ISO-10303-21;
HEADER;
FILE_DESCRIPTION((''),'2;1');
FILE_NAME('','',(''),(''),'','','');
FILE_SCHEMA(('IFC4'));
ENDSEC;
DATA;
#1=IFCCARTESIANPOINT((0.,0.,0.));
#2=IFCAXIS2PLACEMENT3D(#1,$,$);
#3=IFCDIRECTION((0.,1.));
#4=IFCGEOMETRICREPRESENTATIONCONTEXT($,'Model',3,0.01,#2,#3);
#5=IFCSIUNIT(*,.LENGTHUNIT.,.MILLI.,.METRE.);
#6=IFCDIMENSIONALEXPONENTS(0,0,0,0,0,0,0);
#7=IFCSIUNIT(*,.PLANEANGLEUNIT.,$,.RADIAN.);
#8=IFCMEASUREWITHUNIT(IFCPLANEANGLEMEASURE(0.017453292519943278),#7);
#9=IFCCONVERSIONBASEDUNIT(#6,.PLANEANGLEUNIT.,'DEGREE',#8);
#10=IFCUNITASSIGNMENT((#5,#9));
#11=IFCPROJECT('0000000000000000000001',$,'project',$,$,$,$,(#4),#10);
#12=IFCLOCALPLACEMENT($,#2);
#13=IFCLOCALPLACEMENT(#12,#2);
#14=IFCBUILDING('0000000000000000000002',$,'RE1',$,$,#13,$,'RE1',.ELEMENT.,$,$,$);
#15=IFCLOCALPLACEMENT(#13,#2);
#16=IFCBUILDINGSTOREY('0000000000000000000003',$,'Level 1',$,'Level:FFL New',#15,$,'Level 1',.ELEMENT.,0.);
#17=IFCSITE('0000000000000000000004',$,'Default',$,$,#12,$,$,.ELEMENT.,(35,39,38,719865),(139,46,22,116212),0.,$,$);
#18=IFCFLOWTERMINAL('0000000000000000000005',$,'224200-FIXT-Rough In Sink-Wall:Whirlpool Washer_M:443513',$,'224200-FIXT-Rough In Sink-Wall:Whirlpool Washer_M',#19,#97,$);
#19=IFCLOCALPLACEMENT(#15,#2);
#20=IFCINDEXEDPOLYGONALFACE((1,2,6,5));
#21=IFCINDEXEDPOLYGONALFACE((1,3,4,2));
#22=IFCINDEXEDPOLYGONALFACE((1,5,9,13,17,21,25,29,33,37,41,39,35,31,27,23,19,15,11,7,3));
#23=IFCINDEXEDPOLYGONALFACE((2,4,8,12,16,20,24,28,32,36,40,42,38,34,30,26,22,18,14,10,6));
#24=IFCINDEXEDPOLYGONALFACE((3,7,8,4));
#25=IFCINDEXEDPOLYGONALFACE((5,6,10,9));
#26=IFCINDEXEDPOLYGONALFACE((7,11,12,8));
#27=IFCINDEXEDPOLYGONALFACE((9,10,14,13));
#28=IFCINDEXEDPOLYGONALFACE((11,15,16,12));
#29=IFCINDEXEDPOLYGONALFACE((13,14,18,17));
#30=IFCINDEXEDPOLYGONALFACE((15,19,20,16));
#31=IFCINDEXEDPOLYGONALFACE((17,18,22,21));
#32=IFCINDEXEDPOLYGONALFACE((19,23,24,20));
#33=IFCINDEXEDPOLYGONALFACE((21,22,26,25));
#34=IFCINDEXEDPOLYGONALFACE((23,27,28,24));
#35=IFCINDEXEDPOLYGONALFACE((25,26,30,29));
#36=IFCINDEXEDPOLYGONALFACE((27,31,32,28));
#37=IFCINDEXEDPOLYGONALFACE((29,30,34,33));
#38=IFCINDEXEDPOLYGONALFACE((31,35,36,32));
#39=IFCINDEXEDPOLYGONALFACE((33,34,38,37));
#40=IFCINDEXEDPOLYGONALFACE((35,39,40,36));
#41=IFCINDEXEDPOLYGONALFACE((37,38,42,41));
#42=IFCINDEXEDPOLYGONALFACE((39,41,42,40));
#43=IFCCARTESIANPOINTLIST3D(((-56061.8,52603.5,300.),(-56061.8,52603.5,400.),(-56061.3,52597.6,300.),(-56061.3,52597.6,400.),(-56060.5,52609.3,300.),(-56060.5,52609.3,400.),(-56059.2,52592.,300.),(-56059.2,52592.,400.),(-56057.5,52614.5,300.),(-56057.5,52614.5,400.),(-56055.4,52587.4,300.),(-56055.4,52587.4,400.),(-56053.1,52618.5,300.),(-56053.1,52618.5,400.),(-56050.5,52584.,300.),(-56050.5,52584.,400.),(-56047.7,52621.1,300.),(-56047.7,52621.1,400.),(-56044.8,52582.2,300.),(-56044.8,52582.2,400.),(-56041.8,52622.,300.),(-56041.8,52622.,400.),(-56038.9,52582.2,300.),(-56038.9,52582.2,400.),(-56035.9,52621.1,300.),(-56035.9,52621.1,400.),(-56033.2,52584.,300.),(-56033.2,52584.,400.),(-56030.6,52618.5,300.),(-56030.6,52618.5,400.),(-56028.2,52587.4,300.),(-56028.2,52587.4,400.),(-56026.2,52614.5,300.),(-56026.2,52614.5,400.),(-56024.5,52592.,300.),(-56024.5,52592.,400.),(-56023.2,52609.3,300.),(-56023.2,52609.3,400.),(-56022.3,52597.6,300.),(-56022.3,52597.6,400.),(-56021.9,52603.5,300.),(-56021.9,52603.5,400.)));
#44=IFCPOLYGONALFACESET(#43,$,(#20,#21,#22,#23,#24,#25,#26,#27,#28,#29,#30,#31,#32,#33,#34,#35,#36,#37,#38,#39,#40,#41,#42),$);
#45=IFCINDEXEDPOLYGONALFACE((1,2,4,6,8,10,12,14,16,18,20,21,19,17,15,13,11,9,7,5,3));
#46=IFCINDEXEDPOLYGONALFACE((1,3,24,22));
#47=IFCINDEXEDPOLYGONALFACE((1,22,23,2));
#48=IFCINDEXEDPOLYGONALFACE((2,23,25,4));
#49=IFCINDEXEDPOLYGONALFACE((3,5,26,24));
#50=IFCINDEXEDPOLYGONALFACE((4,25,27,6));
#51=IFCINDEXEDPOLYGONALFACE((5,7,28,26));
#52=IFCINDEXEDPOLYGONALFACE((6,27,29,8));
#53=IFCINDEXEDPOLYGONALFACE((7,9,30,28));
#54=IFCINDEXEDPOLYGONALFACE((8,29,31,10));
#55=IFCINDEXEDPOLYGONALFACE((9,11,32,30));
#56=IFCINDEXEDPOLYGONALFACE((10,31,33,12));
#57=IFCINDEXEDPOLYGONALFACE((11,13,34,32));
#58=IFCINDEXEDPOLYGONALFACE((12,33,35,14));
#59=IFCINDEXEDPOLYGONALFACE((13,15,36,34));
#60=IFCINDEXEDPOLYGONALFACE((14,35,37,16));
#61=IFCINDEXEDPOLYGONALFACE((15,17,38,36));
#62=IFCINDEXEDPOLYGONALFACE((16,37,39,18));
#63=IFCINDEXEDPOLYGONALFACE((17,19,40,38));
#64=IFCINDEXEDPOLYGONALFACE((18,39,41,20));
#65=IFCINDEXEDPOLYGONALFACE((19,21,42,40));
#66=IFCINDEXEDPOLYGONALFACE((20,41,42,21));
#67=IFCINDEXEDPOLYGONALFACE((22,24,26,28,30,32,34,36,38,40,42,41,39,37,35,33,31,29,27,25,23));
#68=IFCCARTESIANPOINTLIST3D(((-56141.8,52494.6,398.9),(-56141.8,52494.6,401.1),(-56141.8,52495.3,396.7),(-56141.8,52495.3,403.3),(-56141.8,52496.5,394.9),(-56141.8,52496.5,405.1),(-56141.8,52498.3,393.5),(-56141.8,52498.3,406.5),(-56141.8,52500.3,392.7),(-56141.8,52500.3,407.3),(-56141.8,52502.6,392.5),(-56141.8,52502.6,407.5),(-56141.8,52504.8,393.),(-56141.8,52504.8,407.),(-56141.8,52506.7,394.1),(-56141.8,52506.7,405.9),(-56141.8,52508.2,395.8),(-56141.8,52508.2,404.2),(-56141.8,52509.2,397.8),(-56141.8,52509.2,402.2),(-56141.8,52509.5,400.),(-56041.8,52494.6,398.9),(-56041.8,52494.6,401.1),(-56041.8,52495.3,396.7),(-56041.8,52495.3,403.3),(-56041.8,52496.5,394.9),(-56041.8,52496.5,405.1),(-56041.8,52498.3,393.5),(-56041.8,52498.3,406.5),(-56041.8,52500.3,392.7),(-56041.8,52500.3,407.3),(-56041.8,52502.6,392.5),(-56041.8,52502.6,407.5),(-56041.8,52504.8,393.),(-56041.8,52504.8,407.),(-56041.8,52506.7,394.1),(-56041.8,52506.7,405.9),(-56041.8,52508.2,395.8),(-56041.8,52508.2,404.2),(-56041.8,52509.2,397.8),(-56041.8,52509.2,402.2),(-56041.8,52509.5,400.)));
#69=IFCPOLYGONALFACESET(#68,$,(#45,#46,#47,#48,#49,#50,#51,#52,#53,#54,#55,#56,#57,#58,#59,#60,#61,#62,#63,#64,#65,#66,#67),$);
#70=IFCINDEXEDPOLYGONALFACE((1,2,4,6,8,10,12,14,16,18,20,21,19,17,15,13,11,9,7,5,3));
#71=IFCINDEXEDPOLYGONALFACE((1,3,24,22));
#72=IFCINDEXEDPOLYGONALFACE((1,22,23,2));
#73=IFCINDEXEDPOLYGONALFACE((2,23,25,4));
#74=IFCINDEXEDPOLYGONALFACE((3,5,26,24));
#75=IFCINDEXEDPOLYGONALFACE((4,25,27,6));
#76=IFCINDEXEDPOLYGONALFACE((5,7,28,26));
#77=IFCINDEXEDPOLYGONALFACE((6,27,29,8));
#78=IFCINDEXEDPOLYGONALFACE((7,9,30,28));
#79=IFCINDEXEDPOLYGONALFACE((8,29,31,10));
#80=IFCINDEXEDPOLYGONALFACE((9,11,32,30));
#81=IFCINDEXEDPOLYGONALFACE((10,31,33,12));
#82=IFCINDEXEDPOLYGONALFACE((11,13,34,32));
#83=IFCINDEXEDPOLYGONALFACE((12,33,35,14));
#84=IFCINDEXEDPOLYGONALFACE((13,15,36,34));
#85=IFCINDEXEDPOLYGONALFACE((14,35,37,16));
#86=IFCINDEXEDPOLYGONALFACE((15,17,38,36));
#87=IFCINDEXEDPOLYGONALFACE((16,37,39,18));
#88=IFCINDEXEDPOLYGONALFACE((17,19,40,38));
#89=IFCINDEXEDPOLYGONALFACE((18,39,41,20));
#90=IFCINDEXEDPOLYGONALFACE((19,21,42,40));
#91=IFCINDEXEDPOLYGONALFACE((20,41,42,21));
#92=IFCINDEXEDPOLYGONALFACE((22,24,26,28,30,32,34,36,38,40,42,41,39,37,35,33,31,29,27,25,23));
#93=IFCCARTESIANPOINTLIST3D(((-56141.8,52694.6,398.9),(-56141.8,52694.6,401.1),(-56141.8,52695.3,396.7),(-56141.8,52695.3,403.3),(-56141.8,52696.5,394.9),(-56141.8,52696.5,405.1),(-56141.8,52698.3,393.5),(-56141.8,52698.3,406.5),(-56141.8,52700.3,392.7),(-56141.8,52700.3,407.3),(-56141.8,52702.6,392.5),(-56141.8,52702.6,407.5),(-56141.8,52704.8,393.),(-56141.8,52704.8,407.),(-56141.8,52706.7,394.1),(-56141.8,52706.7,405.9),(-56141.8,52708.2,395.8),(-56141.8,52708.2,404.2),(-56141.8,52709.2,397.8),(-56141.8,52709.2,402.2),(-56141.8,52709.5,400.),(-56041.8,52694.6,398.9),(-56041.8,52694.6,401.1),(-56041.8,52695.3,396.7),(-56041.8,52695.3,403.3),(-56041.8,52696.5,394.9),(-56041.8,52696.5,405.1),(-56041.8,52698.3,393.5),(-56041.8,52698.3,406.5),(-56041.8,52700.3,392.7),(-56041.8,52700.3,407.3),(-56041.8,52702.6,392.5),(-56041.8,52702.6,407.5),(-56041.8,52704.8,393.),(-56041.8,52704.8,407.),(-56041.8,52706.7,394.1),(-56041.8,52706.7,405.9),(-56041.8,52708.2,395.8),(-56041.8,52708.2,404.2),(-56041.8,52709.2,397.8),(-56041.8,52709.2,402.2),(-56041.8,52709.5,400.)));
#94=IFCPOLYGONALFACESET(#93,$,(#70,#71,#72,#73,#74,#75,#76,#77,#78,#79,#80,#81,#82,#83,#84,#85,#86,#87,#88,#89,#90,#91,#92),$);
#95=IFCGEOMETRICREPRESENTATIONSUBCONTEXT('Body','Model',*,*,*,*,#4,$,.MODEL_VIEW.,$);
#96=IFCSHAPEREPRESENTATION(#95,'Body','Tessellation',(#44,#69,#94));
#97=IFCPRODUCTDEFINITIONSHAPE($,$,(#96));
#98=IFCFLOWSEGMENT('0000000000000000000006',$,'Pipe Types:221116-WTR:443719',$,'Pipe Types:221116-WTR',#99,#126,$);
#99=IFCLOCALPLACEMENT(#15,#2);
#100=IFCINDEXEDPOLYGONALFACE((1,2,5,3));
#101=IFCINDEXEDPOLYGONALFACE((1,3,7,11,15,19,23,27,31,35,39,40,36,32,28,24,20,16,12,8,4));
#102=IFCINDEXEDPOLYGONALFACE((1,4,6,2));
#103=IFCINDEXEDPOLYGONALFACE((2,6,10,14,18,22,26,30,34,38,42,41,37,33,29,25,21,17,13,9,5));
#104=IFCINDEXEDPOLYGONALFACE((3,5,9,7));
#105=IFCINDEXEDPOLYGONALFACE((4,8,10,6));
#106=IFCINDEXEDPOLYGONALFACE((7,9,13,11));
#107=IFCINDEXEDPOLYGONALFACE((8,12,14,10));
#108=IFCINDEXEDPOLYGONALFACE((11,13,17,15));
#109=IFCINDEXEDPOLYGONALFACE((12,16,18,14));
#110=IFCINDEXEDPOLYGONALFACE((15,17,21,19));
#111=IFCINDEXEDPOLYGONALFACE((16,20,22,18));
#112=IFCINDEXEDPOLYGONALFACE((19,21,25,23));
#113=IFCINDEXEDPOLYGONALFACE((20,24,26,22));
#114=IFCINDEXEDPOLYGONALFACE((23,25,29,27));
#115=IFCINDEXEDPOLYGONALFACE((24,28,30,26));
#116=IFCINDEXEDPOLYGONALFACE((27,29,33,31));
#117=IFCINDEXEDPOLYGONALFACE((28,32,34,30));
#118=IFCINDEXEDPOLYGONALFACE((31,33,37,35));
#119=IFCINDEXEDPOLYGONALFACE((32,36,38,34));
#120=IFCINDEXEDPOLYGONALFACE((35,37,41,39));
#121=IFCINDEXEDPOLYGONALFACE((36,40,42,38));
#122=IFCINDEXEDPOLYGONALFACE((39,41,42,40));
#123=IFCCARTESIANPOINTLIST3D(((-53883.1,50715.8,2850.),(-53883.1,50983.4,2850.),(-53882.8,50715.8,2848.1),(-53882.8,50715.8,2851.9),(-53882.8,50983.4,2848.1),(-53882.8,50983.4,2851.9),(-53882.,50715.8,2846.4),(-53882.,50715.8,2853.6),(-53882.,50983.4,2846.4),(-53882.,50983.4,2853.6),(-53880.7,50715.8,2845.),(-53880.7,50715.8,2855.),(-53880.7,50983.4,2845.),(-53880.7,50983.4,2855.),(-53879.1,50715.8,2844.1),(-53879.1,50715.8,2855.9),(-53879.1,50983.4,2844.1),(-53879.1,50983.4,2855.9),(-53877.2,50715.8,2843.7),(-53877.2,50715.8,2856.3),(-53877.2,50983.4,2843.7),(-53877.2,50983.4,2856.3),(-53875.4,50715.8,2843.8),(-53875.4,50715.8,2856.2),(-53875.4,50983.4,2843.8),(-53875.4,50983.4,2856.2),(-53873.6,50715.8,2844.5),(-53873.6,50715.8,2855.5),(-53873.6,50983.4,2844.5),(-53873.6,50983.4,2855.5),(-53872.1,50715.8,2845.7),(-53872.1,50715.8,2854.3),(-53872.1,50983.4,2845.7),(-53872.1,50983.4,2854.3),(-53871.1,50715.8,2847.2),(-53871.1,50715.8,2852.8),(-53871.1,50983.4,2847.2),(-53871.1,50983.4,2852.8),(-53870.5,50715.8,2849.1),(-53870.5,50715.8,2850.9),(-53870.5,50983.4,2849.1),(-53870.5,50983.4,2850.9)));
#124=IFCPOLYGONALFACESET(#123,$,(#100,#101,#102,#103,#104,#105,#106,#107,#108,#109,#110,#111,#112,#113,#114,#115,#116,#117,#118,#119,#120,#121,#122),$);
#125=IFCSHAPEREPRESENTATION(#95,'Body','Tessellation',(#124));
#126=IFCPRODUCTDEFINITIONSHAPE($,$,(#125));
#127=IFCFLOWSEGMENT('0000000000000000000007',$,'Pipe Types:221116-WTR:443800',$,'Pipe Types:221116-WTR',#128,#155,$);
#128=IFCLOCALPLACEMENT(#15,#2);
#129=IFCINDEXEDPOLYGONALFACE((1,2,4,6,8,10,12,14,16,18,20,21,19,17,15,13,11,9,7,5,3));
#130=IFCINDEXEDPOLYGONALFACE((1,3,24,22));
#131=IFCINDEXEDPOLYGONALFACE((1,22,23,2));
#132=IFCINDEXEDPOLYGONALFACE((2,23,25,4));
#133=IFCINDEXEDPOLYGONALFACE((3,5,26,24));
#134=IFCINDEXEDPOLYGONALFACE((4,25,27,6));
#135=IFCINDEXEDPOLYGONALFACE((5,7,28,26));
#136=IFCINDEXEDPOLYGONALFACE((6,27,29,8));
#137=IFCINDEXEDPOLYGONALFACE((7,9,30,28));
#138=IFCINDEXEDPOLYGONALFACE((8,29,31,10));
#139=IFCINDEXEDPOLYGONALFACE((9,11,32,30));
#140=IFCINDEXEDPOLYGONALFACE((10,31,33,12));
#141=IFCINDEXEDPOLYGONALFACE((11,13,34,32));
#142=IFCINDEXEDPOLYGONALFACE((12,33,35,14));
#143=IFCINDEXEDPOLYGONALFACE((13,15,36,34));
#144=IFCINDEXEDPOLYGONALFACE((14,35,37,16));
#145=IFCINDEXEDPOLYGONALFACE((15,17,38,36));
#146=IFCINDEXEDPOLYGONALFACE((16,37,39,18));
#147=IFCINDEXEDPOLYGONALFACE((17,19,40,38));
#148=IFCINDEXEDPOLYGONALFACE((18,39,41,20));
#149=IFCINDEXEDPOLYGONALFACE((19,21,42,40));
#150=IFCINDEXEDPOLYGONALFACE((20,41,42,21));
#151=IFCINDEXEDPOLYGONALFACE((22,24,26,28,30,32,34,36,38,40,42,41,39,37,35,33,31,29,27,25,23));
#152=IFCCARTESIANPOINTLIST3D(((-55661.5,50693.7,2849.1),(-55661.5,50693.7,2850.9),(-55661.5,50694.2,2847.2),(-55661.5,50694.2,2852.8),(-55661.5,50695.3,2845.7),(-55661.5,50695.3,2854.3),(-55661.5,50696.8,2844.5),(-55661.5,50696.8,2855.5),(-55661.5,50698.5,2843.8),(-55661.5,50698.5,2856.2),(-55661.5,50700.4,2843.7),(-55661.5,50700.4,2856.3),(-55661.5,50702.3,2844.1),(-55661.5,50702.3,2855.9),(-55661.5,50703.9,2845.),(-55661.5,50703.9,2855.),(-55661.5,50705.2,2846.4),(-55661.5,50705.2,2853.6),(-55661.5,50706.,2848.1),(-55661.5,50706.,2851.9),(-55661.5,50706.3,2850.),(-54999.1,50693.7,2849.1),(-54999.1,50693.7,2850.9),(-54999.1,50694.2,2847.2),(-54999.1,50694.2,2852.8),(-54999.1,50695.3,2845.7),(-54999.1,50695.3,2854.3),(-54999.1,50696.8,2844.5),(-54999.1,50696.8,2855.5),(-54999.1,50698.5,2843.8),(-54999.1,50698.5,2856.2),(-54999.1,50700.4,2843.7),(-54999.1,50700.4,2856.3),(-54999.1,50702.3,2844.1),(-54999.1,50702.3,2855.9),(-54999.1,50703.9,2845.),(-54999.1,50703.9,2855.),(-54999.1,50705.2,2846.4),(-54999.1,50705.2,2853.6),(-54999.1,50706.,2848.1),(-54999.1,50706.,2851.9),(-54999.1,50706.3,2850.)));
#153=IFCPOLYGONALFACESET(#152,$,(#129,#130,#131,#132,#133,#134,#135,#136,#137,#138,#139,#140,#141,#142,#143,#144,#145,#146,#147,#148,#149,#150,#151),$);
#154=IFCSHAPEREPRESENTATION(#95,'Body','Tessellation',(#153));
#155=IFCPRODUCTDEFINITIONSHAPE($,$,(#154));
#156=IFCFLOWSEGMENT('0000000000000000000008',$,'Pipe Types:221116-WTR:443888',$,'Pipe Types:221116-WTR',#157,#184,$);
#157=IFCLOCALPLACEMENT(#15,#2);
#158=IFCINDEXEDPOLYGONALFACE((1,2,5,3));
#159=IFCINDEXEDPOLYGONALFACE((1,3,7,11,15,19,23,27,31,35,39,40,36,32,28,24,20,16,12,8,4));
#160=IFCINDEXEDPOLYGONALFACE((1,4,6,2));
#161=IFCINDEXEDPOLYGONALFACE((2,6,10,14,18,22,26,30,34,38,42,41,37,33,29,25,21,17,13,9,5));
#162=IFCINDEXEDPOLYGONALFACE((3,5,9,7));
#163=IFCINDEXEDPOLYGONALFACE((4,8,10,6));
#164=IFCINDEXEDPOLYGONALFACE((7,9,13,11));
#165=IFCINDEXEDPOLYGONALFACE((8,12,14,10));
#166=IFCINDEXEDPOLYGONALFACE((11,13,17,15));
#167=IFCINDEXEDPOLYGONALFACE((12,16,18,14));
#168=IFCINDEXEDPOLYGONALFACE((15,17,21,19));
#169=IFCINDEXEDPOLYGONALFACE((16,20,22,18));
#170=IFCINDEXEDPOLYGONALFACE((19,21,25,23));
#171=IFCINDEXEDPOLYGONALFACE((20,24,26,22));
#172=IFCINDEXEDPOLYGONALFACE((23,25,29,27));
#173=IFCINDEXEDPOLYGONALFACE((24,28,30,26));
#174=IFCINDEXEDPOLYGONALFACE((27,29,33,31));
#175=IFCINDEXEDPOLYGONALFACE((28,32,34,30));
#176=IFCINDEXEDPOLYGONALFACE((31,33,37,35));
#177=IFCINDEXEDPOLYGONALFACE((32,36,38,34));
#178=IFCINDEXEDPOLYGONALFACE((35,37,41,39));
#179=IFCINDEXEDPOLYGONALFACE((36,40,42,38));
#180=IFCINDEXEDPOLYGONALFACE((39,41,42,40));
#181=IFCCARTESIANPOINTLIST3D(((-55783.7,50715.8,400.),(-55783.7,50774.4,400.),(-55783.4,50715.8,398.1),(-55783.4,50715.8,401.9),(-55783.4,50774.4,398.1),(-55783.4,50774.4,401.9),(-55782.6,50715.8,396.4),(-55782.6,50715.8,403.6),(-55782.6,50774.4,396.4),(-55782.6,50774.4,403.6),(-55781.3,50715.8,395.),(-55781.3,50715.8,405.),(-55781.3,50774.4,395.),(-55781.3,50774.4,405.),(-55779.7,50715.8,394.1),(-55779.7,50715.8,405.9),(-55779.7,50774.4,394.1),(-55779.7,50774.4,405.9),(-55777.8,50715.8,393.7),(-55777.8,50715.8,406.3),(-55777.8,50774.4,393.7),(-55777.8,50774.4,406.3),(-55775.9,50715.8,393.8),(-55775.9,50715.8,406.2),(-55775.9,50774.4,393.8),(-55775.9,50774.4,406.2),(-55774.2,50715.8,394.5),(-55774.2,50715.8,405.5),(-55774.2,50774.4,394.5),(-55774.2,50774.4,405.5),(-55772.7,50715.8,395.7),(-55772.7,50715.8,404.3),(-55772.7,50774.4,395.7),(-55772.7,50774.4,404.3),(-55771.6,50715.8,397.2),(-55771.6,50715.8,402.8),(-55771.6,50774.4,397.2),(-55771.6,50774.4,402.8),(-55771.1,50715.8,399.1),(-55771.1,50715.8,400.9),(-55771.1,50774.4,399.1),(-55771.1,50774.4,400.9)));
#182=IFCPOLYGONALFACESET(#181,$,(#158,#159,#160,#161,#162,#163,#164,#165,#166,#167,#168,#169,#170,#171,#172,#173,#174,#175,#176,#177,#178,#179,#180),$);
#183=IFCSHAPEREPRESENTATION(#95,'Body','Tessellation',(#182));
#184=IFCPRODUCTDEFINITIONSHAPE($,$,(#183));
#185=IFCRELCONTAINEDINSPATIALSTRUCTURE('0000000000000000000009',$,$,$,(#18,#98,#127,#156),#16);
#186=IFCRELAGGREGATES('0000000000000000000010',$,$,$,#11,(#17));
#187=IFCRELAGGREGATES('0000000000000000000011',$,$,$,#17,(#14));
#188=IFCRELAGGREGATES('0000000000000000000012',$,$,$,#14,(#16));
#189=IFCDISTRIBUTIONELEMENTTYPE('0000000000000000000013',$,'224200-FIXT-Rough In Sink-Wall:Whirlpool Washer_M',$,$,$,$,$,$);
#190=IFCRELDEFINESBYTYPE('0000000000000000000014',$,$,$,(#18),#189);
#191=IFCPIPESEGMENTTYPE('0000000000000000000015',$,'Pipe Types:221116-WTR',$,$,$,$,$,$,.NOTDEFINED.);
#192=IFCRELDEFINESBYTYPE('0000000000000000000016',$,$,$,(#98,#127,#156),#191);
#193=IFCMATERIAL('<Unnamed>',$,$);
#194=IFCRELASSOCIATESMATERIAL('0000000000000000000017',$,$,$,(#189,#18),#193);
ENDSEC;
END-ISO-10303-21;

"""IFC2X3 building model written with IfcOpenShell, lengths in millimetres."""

from ifc_helpers import new_model, entity, si_unit, converted_unit, direction, frame, frame_2d, origin, origin_2d_with_axis, place, context, subcontext, project, spatial, circle, extrude, source, transform, mapped, material, type_object, type_shapes, element, save


model = new_model("IFC2X3")

# Units and contexts
model_context = context("Model", 3, precision=0.01, world=origin(), true_north=direction((0.0, 1.0)))
body_context = subcontext(model_context, "Body", "Model", "MODEL_VIEW")
ifc_project = project(units=[si_unit("LENGTHUNIT", "METRE", prefix="MILLI"), converted_unit("PLANEANGLEUNIT", "DEGREE", entity("IfcPlaneAngleMeasure", 0.017453292519943278), si_unit("PLANEANGLEUNIT", "RADIAN"), dimensions=[0, 0, 0, 0, 0, 0, 0])], contexts=[model_context])

# Site, building, storey
site_placement = place(None, origin())
site = spatial("IfcSite", under=ifc_project, at=site_placement, Name="Default", CompositionType="ELEMENT", RefLatitude=(35, 39, 38, 719865), RefLongitude=(139, 46, 22, 116212), RefElevation=0.0)
building_placement = place(site_placement, origin())
building = spatial("IfcBuilding", under=site, at=building_placement, Name="RE1", LongName="RE1", CompositionType="ELEMENT")
storey_placement = place(building_placement, origin())
storey = spatial("IfcBuildingStorey", under=building, at=storey_placement, Name="Level 1", ObjectType="Level:FFL New", LongName="Level 1", CompositionType="ELEMENT", Elevation=0.0)

# Flow terminal
ifc_material = material(Name="<Unnamed>")
distribution_element_type_1 = type_object("IfcDistributionElementType", Name="224200-FIXT-Rough In Sink-Wall:Whirlpool Washer_M", material=ifc_material)
shared_shape_1 = source(origin(), body_context, "Body", "SweptSolid", [
    extrude(circle(Radius=20.0, at=frame_2d((0.0, 0.0), x_axis=(1.0, 0.0))), frame((0.0, -100.0, 100.0), z_axis=(0.0, 1.0, 0.0), x_axis=(1.0, 0.0, 0.0)), (0.0, 0.0, 1.0), 100.0),
    extrude(circle(Radius=7.5, at=frame_2d((0.0, 0.0), x_axis=(1.0, 0.0))), frame((-100.0, 0.0, 0.0)), (0.0, 0.0, 1.0), 100.0),
    extrude(circle(Radius=7.5, at=frame_2d((0.0, 0.0), x_axis=(1.0, 0.0))), frame((100.0, 0.0, 0.0)), (0.0, 0.0, 1.0), 100.0),
])
type_shapes(distribution_element_type_1, [shared_shape_1])
flow_terminal_1_placement = place(storey_placement, frame((-56141.8, 52602.0, 400.0), z_axis=(1.0, -0.000002, 0.0), x_axis=(0.000002, 1.0, 0.0)))
element("IfcFlowTerminal", 1, at=flow_terminal_1_placement, inside=storey, type_object=distribution_element_type_1, material=ifc_material, Name="224200-FIXT-Rough In Sink-Wall:Whirlpool Washer_M:443513", ObjectType="224200-FIXT-Rough In Sink-Wall:Whirlpool Washer_M", context=body_context, shape_type="MappedRepresentation", body=[
    mapped(shared_shape_1, transform((0.0, 0.0, 0.0), scale=1.0)),
])

# Flow segments
pipe_segment_type_1 = type_object("IfcPipeSegmentType", Name="Pipe Types:221116-WTR", PredefinedType="NOTDEFINED")
flow_segment_1_placement = place(storey_placement, origin())
element("IfcFlowSegment", 2, at=flow_segment_1_placement, inside=storey, type_object=pipe_segment_type_1, Name="Pipe Types:221116-WTR:443719", ObjectType="Pipe Types:221116-WTR", context=body_context, shape_type="SweptSolid", body=[
    extrude(circle(Radius=6.3, at=frame_2d((0.0, 0.0), x_axis=(1.0, 0.0))), frame((-53876.8, 50715.8, 2850.0), z_axis=(0.0, 1.0, 0.0), x_axis=(-1.0, 0.0, 0.0)), (0.0, 0.0, 1.0), 267.6),
])
flow_segment_2_placement = place(storey_placement, origin())
element("IfcFlowSegment", 3, at=flow_segment_2_placement, inside=storey, type_object=pipe_segment_type_1, Name="Pipe Types:221116-WTR:443800", ObjectType="Pipe Types:221116-WTR", context=body_context, shape_type="SweptSolid", body=[
    extrude(circle(Radius=6.3, at=origin_2d_with_axis()), frame((-55661.5, 50699.9, 2850.0), z_axis=(1.0, 0.0, 0.0), x_axis=(0.0, 1.0, 0.0)), (0.0, 0.0, 1.0), 662.4),
])
flow_segment_3_placement = place(storey_placement, origin())
element("IfcFlowSegment", 4, at=flow_segment_3_placement, inside=storey, type_object=pipe_segment_type_1, Name="Pipe Types:221116-WTR:443888", ObjectType="Pipe Types:221116-WTR", context=body_context, shape_type="SweptSolid", body=[
    extrude(circle(Radius=6.3, at=origin_2d_with_axis()), frame((-55777.4, 50715.8, 400.0), z_axis=(0.0, 1.0, 0.0), x_axis=(-1.0, 0.0, 0.0)), (0.0, 0.0, 1.0), 58.6),
])

save(model, "model.ifc")
